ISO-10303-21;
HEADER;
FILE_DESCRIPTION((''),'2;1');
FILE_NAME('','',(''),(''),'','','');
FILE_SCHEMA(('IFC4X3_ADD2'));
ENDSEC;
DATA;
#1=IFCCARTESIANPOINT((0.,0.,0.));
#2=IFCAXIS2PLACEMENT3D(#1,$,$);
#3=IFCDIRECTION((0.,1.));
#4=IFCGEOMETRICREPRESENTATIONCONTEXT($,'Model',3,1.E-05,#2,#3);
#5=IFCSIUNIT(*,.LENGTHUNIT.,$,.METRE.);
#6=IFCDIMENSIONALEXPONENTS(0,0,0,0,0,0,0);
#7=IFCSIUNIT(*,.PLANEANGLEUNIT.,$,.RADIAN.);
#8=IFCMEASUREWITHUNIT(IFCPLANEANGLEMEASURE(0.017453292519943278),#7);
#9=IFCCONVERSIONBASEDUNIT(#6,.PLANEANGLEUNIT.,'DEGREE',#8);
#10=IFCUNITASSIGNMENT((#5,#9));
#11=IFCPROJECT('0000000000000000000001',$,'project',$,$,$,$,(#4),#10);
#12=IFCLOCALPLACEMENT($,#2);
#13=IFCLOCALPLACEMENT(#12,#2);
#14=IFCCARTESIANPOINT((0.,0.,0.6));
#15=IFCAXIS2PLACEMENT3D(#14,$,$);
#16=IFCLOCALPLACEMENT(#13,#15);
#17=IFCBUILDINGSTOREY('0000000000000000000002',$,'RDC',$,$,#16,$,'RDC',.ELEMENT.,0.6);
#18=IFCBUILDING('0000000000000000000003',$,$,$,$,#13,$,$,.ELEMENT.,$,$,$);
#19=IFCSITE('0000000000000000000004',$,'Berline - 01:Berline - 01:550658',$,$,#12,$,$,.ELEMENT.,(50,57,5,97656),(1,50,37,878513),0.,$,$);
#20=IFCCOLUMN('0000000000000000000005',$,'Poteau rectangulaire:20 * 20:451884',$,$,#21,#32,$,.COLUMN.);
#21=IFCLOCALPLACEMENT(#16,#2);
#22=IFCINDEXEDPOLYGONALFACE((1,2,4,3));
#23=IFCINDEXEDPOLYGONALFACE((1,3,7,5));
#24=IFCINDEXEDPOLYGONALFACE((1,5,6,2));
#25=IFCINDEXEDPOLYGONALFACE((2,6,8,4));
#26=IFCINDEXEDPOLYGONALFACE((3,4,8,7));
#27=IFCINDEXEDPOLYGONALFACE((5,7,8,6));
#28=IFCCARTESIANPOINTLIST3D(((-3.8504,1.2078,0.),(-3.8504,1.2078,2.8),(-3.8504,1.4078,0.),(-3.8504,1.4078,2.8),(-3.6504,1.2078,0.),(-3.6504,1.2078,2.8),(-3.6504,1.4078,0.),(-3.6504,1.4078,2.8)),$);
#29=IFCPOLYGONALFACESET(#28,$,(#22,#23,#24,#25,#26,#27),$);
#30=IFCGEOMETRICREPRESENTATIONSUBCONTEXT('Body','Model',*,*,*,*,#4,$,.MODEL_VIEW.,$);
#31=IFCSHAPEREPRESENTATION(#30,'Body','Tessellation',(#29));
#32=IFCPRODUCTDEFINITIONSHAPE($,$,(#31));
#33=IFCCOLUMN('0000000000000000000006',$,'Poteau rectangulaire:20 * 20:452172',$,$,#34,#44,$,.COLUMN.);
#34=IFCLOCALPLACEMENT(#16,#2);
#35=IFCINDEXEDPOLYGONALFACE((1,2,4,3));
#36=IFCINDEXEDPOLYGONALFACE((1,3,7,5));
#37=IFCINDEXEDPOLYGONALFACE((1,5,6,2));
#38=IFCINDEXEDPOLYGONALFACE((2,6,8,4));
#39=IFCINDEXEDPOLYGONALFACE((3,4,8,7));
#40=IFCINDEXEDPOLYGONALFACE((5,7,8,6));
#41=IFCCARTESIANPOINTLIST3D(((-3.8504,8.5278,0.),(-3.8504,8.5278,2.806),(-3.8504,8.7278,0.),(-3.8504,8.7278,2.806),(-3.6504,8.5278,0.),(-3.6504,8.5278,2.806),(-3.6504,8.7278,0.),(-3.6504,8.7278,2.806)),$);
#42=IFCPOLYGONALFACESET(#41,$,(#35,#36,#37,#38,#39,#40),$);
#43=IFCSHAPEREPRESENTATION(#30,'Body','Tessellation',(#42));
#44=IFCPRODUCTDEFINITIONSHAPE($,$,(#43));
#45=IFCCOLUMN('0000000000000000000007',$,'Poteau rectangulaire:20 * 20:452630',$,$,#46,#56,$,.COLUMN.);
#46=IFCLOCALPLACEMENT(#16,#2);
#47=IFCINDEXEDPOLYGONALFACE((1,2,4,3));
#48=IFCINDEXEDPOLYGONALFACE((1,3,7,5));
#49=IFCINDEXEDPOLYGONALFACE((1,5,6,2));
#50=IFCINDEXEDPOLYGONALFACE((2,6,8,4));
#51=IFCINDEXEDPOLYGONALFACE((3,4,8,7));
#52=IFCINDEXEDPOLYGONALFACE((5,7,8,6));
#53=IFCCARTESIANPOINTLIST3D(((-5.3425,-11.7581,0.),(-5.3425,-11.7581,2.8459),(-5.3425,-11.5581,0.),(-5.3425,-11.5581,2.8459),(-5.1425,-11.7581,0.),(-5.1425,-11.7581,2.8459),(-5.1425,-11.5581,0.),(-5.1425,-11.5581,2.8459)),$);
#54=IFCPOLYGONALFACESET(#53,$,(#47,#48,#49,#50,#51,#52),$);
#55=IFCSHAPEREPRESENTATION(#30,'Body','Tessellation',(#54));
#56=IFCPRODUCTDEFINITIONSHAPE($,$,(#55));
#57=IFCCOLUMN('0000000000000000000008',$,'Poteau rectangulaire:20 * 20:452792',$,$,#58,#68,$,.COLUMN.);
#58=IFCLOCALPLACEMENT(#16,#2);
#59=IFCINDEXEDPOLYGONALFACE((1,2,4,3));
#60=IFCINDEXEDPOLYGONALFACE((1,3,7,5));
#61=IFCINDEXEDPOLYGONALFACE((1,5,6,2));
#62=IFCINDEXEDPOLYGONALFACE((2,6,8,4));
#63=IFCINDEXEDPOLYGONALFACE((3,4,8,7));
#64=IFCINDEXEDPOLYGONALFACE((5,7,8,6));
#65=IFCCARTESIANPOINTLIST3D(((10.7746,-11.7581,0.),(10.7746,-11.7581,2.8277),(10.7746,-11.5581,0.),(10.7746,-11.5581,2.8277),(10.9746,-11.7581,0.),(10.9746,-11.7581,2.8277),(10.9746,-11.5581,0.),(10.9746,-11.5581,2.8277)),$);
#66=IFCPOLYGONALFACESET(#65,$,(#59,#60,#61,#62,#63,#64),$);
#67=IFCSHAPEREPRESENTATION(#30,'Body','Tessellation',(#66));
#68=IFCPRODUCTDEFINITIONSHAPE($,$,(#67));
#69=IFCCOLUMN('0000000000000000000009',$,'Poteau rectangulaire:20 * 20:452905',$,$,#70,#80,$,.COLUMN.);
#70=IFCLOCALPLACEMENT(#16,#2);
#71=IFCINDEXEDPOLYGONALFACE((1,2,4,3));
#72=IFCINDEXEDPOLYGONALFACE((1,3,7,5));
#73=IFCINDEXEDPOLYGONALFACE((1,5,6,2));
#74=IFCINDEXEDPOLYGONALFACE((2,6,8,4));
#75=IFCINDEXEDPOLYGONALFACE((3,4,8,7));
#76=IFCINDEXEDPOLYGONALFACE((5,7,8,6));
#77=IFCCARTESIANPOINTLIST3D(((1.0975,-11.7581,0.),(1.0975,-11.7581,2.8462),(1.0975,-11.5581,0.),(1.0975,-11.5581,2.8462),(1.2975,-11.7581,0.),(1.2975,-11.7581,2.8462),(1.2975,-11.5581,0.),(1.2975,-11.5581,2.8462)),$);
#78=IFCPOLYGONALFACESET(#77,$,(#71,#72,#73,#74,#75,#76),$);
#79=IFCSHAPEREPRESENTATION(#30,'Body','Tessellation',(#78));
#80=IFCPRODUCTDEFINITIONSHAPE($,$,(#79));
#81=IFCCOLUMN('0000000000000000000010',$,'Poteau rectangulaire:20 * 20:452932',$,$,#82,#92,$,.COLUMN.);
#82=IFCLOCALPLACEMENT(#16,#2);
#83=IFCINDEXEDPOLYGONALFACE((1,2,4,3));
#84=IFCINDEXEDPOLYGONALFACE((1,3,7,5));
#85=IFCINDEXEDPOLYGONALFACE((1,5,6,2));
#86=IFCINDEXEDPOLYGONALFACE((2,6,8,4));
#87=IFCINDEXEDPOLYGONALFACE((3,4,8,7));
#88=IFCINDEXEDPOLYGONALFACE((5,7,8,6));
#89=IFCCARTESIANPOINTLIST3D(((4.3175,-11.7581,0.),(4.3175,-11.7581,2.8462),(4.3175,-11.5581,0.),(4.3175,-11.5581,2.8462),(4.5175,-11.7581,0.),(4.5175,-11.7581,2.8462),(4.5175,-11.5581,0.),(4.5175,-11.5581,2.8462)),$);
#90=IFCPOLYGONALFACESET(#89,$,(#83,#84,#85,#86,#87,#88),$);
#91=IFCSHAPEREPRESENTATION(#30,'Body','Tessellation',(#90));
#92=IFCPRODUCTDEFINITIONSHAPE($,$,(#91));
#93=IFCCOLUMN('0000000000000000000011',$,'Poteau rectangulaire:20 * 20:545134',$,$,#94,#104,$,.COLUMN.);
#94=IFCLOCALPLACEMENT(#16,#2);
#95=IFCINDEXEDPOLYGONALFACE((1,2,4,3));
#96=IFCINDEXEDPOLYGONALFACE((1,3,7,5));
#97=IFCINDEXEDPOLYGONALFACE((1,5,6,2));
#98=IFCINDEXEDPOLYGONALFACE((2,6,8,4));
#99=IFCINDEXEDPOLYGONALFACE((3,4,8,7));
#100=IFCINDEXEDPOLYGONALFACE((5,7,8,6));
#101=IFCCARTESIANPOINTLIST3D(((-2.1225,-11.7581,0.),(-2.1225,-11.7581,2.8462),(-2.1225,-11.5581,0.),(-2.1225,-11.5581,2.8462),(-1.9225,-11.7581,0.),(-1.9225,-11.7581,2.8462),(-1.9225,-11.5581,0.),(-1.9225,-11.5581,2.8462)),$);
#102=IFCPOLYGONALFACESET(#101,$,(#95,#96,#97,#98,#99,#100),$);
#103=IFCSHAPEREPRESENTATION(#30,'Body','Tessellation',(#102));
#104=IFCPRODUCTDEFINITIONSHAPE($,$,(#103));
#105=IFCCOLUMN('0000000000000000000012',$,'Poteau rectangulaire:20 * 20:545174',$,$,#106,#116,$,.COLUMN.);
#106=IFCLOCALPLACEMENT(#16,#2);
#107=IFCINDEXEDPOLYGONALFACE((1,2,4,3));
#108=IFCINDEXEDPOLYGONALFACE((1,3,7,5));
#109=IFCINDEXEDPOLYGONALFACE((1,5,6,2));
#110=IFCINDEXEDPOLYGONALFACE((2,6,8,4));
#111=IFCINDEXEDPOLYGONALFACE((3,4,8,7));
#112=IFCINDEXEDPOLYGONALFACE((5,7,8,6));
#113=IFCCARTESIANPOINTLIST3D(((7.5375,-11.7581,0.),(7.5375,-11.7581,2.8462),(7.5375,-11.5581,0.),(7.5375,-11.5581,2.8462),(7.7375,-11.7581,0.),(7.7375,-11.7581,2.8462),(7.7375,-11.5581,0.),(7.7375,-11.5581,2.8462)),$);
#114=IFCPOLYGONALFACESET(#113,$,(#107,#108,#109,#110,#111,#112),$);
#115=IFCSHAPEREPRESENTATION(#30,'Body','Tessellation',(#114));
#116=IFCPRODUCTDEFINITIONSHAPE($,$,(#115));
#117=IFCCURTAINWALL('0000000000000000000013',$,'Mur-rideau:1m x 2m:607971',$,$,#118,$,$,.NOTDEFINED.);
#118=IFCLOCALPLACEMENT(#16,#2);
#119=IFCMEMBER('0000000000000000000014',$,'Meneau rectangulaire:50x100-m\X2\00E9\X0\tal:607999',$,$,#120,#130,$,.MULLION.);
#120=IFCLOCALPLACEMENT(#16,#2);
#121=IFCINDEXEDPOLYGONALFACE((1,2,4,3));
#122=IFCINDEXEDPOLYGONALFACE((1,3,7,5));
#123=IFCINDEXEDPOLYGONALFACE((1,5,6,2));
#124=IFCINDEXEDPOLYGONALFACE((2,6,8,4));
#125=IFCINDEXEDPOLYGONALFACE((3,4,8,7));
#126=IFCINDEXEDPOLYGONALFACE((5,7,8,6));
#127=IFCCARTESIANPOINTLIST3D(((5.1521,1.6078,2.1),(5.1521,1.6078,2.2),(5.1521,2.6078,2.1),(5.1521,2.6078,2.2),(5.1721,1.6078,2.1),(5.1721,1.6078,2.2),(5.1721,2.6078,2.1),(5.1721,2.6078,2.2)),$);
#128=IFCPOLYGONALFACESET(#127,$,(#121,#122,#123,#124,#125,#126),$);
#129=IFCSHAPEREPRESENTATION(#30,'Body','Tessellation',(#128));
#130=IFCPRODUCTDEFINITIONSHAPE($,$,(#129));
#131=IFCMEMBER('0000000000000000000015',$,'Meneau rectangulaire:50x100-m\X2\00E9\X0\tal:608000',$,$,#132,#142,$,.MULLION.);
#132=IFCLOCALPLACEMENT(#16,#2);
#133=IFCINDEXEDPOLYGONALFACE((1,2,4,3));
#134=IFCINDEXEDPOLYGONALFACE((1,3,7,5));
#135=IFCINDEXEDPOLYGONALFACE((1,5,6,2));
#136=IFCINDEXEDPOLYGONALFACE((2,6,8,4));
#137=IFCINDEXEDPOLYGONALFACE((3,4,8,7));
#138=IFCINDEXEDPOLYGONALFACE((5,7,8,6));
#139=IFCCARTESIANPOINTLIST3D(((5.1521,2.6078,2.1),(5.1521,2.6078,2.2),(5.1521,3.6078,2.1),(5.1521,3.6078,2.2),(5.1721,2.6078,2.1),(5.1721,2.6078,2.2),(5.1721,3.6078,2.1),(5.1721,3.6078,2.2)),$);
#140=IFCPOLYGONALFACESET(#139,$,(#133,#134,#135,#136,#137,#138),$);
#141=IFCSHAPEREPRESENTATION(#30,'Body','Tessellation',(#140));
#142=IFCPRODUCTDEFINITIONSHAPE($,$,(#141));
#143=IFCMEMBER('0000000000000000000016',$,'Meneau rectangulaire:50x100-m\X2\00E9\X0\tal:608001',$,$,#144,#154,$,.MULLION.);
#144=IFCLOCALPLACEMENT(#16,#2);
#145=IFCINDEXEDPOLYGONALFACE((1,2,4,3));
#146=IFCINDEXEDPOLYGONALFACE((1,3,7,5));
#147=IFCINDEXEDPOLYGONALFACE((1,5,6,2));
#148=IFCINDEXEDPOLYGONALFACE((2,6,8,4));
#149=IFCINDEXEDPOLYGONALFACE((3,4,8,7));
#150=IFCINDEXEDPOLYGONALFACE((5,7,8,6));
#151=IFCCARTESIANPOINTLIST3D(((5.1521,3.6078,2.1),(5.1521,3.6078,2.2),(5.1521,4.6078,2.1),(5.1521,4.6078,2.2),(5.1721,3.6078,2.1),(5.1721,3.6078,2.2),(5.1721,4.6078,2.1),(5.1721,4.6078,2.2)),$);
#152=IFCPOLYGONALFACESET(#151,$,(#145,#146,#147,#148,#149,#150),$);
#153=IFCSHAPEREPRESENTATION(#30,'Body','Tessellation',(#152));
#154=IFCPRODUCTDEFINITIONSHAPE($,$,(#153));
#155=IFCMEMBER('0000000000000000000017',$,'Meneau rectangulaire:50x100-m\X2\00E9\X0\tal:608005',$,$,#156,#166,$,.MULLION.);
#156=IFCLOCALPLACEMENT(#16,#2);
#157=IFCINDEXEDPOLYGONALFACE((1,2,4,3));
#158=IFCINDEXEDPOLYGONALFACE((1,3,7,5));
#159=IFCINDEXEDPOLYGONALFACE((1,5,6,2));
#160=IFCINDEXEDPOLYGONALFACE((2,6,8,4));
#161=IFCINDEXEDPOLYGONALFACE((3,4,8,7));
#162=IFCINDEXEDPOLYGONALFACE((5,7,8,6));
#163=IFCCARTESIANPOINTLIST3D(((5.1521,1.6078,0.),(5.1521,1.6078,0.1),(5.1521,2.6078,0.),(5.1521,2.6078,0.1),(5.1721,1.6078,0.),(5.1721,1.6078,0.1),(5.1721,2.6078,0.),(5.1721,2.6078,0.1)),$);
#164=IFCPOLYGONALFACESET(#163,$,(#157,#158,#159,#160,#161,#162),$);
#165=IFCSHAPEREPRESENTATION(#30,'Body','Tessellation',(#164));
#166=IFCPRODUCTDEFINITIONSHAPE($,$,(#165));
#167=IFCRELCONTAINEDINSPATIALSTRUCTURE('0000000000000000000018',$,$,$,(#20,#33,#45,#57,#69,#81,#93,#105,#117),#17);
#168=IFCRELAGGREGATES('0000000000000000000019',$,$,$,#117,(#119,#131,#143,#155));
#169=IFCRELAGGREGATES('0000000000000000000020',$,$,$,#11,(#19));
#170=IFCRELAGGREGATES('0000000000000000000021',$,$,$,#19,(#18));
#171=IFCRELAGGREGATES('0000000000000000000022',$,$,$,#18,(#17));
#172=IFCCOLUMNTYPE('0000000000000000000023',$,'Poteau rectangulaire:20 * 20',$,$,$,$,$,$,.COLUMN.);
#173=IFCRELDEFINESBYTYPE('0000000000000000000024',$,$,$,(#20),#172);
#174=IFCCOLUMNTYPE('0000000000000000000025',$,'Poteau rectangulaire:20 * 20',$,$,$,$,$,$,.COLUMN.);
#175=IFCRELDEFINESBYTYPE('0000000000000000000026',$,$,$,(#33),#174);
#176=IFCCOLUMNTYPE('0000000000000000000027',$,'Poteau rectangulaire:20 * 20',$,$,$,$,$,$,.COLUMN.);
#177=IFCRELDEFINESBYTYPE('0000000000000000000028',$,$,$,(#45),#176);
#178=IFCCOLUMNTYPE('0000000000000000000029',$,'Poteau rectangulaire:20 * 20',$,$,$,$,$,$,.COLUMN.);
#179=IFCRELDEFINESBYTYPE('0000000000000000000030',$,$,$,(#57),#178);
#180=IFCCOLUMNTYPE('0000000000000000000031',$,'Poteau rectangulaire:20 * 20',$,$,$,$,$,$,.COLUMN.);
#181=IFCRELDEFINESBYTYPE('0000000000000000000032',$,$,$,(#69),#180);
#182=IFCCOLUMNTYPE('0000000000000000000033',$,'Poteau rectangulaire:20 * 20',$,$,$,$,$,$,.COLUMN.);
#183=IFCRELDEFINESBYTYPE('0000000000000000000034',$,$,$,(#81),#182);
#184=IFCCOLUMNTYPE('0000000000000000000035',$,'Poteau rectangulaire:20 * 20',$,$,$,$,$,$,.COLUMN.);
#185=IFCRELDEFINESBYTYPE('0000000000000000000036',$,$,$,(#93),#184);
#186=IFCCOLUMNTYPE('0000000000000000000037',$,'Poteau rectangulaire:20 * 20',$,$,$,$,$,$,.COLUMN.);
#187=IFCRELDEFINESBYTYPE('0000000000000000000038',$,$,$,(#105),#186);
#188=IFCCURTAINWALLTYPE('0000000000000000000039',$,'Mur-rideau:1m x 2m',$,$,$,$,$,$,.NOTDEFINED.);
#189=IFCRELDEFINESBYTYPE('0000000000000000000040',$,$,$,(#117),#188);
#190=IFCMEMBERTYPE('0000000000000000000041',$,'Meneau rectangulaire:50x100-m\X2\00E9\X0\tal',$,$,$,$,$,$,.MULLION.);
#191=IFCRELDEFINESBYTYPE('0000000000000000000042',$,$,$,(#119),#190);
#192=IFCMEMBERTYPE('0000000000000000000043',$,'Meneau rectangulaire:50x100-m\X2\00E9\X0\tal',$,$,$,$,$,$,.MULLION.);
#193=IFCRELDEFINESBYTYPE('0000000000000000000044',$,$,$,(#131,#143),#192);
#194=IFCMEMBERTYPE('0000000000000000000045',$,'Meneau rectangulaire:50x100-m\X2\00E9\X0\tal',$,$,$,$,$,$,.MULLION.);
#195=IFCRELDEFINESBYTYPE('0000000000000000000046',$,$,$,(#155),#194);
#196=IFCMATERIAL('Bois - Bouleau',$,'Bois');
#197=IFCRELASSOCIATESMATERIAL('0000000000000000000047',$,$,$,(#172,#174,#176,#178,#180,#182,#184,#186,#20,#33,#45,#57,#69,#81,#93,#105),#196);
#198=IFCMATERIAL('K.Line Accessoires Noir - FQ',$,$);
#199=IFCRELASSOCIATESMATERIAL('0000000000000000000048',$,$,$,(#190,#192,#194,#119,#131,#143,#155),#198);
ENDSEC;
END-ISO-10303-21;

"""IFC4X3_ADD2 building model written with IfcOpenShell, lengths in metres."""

from ifc_helpers import new_model, entity, si_unit, converted_unit, direction, frame, frame_2d, origin, origin_2d_with_axis, place, context, subcontext, project, spatial, rectangle, extrude, source, transform, mapped, material, material_profile, profile_set, profile_usage, type_object, type_shapes, element, aggregate, save


model = new_model("IFC4X3_ADD2")

# Units and contexts
model_context = context("Model", 3, precision=1e-05, world=origin(), true_north=direction((0.0, 1.0)))
body_context = subcontext(model_context, "Body", "Model", "MODEL_VIEW")
ifc_project = project(units=[si_unit("LENGTHUNIT", "METRE"), converted_unit("PLANEANGLEUNIT", "DEGREE", entity("IfcPlaneAngleMeasure", 0.017453292519943278), si_unit("PLANEANGLEUNIT", "RADIAN"), dimensions=[0, 0, 0, 0, 0, 0, 0])], contexts=[model_context])

# Site, building, storey
site_placement = place(None, origin())
site = spatial("IfcSite", under=ifc_project, at=site_placement, Name="Berline - 01:Berline - 01:550658", CompositionType="ELEMENT", RefLatitude=(50, 57, 5, 97656), RefLongitude=(1, 50, 37, 878513), RefElevation=0.0)
building_placement = place(site_placement, origin())
building = spatial("IfcBuilding", under=site, at=building_placement, CompositionType="ELEMENT")
storey_placement = place(building_placement, frame((0.0, 0.0, 0.6)))
storey = spatial("IfcBuildingStorey", under=building, at=storey_placement, Name="RDC", LongName="RDC", CompositionType="ELEMENT", Elevation=0.6)

# Columns
ifc_material_1 = material(Name="Bois - Bouleau", Category="Bois")
ifc_material_profile_1 = material_profile(ifc_material_1, rectangle(XDim=0.2, YDim=0.2, at=frame_2d((0.0, 0.0), x_axis=(1.0, 0.0))), Name="20 * 20")
ifc_profile_set_1 = profile_set([ifc_material_profile_1], Name="20 * 20")
ifc_profile_usage_1 = profile_usage(ifc_profile_set_1)
column_type_1 = type_object("IfcColumnType", Name="Poteau rectangulaire:20 * 20", PredefinedType="COLUMN", material=ifc_profile_set_1)
shared_shape_1 = source(origin(), body_context, "Body", "SweptSolid", [
    extrude(rectangle(XDim=0.2, YDim=0.2, at=frame_2d((0.0, 0.0), x_axis=(1.0, 0.0))), frame((-3.7504, 1.3078, 0.6), z_axis=(0.0, 0.0, 1.0), x_axis=(-1.0, 0.0, 0.0)), (0.0, 0.0, 1.0), 2.8),
])
type_shapes(column_type_1, [shared_shape_1])
column_1_placement = place(storey_placement, frame((0.0, 0.0, -0.6)))
element("IfcColumn", 1, at=column_1_placement, inside=storey, type_object=column_type_1, material=ifc_profile_usage_1, Name="Poteau rectangulaire:20 * 20:451884", PredefinedType="COLUMN", context=body_context, shape_type="MappedRepresentation", body=[
    mapped(shared_shape_1, transform((0.0, 0.0, 0.0), scale=1.0)),
])
column_type_2 = type_object("IfcColumnType", Name="Poteau rectangulaire:20 * 20", PredefinedType="COLUMN", material=ifc_profile_set_1)
shared_shape_2 = source(origin(), body_context, "Body", "SweptSolid", [
    extrude(rectangle(XDim=0.2, YDim=0.2, at=frame_2d((0.0, 0.0), x_axis=(1.0, 0.0))), frame((-3.7504, 8.6278, 0.6), z_axis=(0.0, 0.0, 1.0), x_axis=(-1.0, 0.0, 0.0)), (0.0, 0.0, 1.0), 2.806),
])
type_shapes(column_type_2, [shared_shape_2])
column_2_placement = place(storey_placement, frame((0.0, 0.0, -0.6)))
element("IfcColumn", 2, at=column_2_placement, inside=storey, type_object=column_type_2, material=ifc_profile_usage_1, Name="Poteau rectangulaire:20 * 20:452172", PredefinedType="COLUMN", context=body_context, shape_type="MappedRepresentation", body=[
    mapped(shared_shape_2, transform((0.0, 0.0, 0.0), scale=1.0)),
])
column_type_3 = type_object("IfcColumnType", Name="Poteau rectangulaire:20 * 20", PredefinedType="COLUMN", material=ifc_profile_set_1)
shared_shape_3 = source(origin(), body_context, "Body", "SweptSolid", [
    extrude(rectangle(XDim=0.2, YDim=0.2, at=frame_2d((0.0, 0.0), x_axis=(1.0, 0.0))), frame((-5.2425, -11.6581, 0.6), z_axis=(0.0, 0.0, 1.0), x_axis=(-1.0, 0.0, 0.0)), (0.0, 0.0, 1.0), 2.8459),
])
type_shapes(column_type_3, [shared_shape_3])
column_3_placement = place(storey_placement, frame((0.0, 0.0, -0.6)))
element("IfcColumn", 3, at=column_3_placement, inside=storey, type_object=column_type_3, material=ifc_profile_usage_1, Name="Poteau rectangulaire:20 * 20:452630", PredefinedType="COLUMN", context=body_context, shape_type="MappedRepresentation", body=[
    mapped(shared_shape_3, transform((0.0, 0.0, 0.0), scale=1.0)),
])
column_type_4 = type_object("IfcColumnType", Name="Poteau rectangulaire:20 * 20", PredefinedType="COLUMN", material=ifc_profile_set_1)
shared_shape_4 = source(origin(), body_context, "Body", "SweptSolid", [
    extrude(rectangle(XDim=0.2, YDim=0.2, at=frame_2d((0.0, 0.0), x_axis=(1.0, 0.0))), frame((10.8746, -11.6581, 0.6), z_axis=(0.0, 0.0, 1.0), x_axis=(-1.0, 0.0, 0.0)), (0.0, 0.0, 1.0), 2.8277),
])
type_shapes(column_type_4, [shared_shape_4])
column_4_placement = place(storey_placement, frame((0.0, 0.0, -0.6)))
element("IfcColumn", 4, at=column_4_placement, inside=storey, type_object=column_type_4, material=ifc_profile_usage_1, Name="Poteau rectangulaire:20 * 20:452792", PredefinedType="COLUMN", context=body_context, shape_type="MappedRepresentation", body=[
    mapped(shared_shape_4, transform((0.0, 0.0, 0.0), scale=1.0)),
])
column_type_5 = type_object("IfcColumnType", Name="Poteau rectangulaire:20 * 20", PredefinedType="COLUMN", material=ifc_profile_set_1)
shared_shape_5 = source(origin(), body_context, "Body", "SweptSolid", [
    extrude(rectangle(XDim=0.2, YDim=0.2, at=frame_2d((0.0, 0.0), x_axis=(1.0, 0.0))), frame((1.1975, -11.6581, 0.6), z_axis=(0.0, 0.0, 1.0), x_axis=(-1.0, 0.0, 0.0)), (0.0, 0.0, 1.0), 2.8462),
])
type_shapes(column_type_5, [shared_shape_5])
column_5_placement = place(storey_placement, frame((0.0, 0.0, -0.6)))
element("IfcColumn", 5, at=column_5_placement, inside=storey, type_object=column_type_5, material=ifc_profile_usage_1, Name="Poteau rectangulaire:20 * 20:452905", PredefinedType="COLUMN", context=body_context, shape_type="MappedRepresentation", body=[
    mapped(shared_shape_5, transform((0.0, 0.0, 0.0), scale=1.0)),
])
column_type_6 = type_object("IfcColumnType", Name="Poteau rectangulaire:20 * 20", PredefinedType="COLUMN", material=ifc_profile_set_1)
shared_shape_6 = source(origin(), body_context, "Body", "SweptSolid", [
    extrude(rectangle(XDim=0.2, YDim=0.2, at=frame_2d((0.0, 0.0), x_axis=(1.0, 0.0))), frame((4.4175, -11.6581, 0.6), z_axis=(0.0, 0.0, 1.0), x_axis=(-1.0, 0.0, 0.0)), (0.0, 0.0, 1.0), 2.8462),
])
type_shapes(column_type_6, [shared_shape_6])
column_6_placement = place(storey_placement, frame((0.0, 0.0, -0.6)))
element("IfcColumn", 6, at=column_6_placement, inside=storey, type_object=column_type_6, material=ifc_profile_usage_1, Name="Poteau rectangulaire:20 * 20:452932", PredefinedType="COLUMN", context=body_context, shape_type="MappedRepresentation", body=[
    mapped(shared_shape_6, transform((0.0, 0.0, 0.0), scale=1.0)),
])
column_type_7 = type_object("IfcColumnType", Name="Poteau rectangulaire:20 * 20", PredefinedType="COLUMN", material=ifc_profile_set_1)
shared_shape_7 = source(origin(), body_context, "Body", "SweptSolid", [
    extrude(rectangle(XDim=0.2, YDim=0.2, at=frame_2d((0.0, 0.0), x_axis=(1.0, 0.0))), frame((-2.0225, -11.6581, 0.6), z_axis=(0.0, 0.0, 1.0), x_axis=(-1.0, 0.0, 0.0)), (0.0, 0.0, 1.0), 2.8462),
])
type_shapes(column_type_7, [shared_shape_7])
column_7_placement = place(storey_placement, frame((0.0, 0.0, -0.6)))
element("IfcColumn", 7, at=column_7_placement, inside=storey, type_object=column_type_7, material=ifc_profile_usage_1, Name="Poteau rectangulaire:20 * 20:545134", PredefinedType="COLUMN", context=body_context, shape_type="MappedRepresentation", body=[
    mapped(shared_shape_7, transform((0.0, 0.0, 0.0), scale=1.0)),
])
column_type_8 = type_object("IfcColumnType", Name="Poteau rectangulaire:20 * 20", PredefinedType="COLUMN", material=ifc_profile_set_1)
shared_shape_8 = source(origin(), body_context, "Body", "SweptSolid", [
    extrude(rectangle(XDim=0.2, YDim=0.2, at=frame_2d((0.0, 0.0), x_axis=(1.0, 0.0))), frame((7.6375, -11.6581, 0.6), z_axis=(0.0, 0.0, 1.0), x_axis=(-1.0, 0.0, 0.0)), (0.0, 0.0, 1.0), 2.8462),
])
type_shapes(column_type_8, [shared_shape_8])
column_8_placement = place(storey_placement, frame((0.0, 0.0, -0.6)))
element("IfcColumn", 8, at=column_8_placement, inside=storey, type_object=column_type_8, material=ifc_profile_usage_1, Name="Poteau rectangulaire:20 * 20:545174", PredefinedType="COLUMN", context=body_context, shape_type="MappedRepresentation", body=[
    mapped(shared_shape_8, transform((0.0, 0.0, 0.0), scale=1.0)),
])

# Curtain wall, members
curtain_wall_type = type_object("IfcCurtainWallType", Name="Mur-rideau:1m x 2m", PredefinedType="NOTDEFINED")
curtain_wall_placement = place(storey_placement, frame((0.0, 0.0, -0.6)))
curtain_wall = element("IfcCurtainWall", 9, at=curtain_wall_placement, inside=storey, type_object=curtain_wall_type, Name="Mur-rideau:1m x 2m:607971", PredefinedType="NOTDEFINED")
ifc_material_2 = material(Name="K.Line Accessoires Noir - FQ")
ifc_material_profile_2 = material_profile(ifc_material_2, rectangle(XDim=0.1, YDim=0.02, at=origin_2d_with_axis()), Name="50x100-métal")
ifc_profile_set_2 = profile_set([ifc_material_profile_2], Name="50x100-métal")
ifc_profile_usage_2 = profile_usage(ifc_profile_set_2)
member_type_1 = type_object("IfcMemberType", Name="Meneau rectangulaire:50x100-métal", PredefinedType="MULLION", material=ifc_profile_set_2)
shared_shape_9 = source(origin(), body_context, "Body", "SweptSolid", [
    extrude(rectangle(XDim=0.02, YDim=0.1, at=origin_2d_with_axis()), frame((-0.05, -0.01, -1.0), z_axis=(0.0, 0.0, 1.0), x_axis=(0.0, 1.0, 0.0)), (0.0, 0.0, 1.0), 1.0),
])
type_shapes(member_type_1, [shared_shape_9])
member_1_placement = place(curtain_wall_placement, frame((5.1721, 2.6078, 2.8), z_axis=(0.0, 1.0, 0.0), x_axis=(0.0, 0.0, 1.0)))
member_1 = element("IfcMember", 10, at=member_1_placement, type_object=member_type_1, material=ifc_profile_usage_2, Name="Meneau rectangulaire:50x100-métal:607999", PredefinedType="MULLION", context=body_context, shape_type="MappedRepresentation", body=[
    mapped(shared_shape_9, transform((0.0, 0.0, 0.0), scale=1.0)),
])
member_type_2 = type_object("IfcMemberType", Name="Meneau rectangulaire:50x100-métal", PredefinedType="MULLION", material=ifc_profile_set_2)
shared_shape_10 = source(origin(), body_context, "Body", "SweptSolid", [
    extrude(rectangle(XDim=0.02, YDim=0.1, at=origin_2d_with_axis()), frame((-0.05, -0.01, -1.0), z_axis=(0.0, 0.0, 1.0), x_axis=(0.0, 1.0, 0.0)), (0.0, 0.0, 1.0), 1.0),
])
type_shapes(member_type_2, [shared_shape_10])
member_2_placement = place(curtain_wall_placement, frame((5.1721, 3.6078, 2.8), z_axis=(0.0, 1.0, 0.0), x_axis=(0.0, 0.0, 1.0)))
member_2 = element("IfcMember", 11, at=member_2_placement, type_object=member_type_2, material=ifc_profile_usage_2, Name="Meneau rectangulaire:50x100-métal:608000", PredefinedType="MULLION", context=body_context, shape_type="MappedRepresentation", body=[
    mapped(shared_shape_10, transform((0.0, 0.0, 0.0), scale=1.0)),
])
member_3_placement = place(curtain_wall_placement, frame((5.1721, 4.6078, 2.8), z_axis=(0.0, 1.0, 0.0), x_axis=(0.0, 0.0, 1.0)))
member_3 = element("IfcMember", 12, at=member_3_placement, type_object=member_type_2, material=ifc_profile_usage_2, Name="Meneau rectangulaire:50x100-métal:608001", PredefinedType="MULLION", context=body_context, shape_type="MappedRepresentation", body=[
    mapped(shared_shape_10, transform((0.0, 0.0, 0.0), scale=1.0)),
])
member_type_3 = type_object("IfcMemberType", Name="Meneau rectangulaire:50x100-métal", PredefinedType="MULLION", material=ifc_profile_set_2)
shared_shape_11 = source(origin(), body_context, "Body", "SweptSolid", [
    extrude(rectangle(XDim=0.1, YDim=0.02, at=origin_2d_with_axis()), frame((-0.05, -0.01, -1.0)), (0.0, 0.0, 1.0), 1.0),
])
type_shapes(member_type_3, [shared_shape_11])
member_4_placement = place(curtain_wall_placement, frame((5.1721, 1.6078, 0.6), z_axis=(0.0, -1.0, 0.0), x_axis=(0.0, 0.0, -1.0)))
member_4 = element("IfcMember", 13, at=member_4_placement, type_object=member_type_3, material=ifc_profile_usage_2, Name="Meneau rectangulaire:50x100-métal:608005", PredefinedType="MULLION", context=body_context, shape_type="MappedRepresentation", body=[
    mapped(shared_shape_11, transform((0.0, 0.0, 0.0), scale=1.0)),
])

aggregate(curtain_wall, [member_1, member_2, member_3, member_4])

save(model, "model.ifc")
